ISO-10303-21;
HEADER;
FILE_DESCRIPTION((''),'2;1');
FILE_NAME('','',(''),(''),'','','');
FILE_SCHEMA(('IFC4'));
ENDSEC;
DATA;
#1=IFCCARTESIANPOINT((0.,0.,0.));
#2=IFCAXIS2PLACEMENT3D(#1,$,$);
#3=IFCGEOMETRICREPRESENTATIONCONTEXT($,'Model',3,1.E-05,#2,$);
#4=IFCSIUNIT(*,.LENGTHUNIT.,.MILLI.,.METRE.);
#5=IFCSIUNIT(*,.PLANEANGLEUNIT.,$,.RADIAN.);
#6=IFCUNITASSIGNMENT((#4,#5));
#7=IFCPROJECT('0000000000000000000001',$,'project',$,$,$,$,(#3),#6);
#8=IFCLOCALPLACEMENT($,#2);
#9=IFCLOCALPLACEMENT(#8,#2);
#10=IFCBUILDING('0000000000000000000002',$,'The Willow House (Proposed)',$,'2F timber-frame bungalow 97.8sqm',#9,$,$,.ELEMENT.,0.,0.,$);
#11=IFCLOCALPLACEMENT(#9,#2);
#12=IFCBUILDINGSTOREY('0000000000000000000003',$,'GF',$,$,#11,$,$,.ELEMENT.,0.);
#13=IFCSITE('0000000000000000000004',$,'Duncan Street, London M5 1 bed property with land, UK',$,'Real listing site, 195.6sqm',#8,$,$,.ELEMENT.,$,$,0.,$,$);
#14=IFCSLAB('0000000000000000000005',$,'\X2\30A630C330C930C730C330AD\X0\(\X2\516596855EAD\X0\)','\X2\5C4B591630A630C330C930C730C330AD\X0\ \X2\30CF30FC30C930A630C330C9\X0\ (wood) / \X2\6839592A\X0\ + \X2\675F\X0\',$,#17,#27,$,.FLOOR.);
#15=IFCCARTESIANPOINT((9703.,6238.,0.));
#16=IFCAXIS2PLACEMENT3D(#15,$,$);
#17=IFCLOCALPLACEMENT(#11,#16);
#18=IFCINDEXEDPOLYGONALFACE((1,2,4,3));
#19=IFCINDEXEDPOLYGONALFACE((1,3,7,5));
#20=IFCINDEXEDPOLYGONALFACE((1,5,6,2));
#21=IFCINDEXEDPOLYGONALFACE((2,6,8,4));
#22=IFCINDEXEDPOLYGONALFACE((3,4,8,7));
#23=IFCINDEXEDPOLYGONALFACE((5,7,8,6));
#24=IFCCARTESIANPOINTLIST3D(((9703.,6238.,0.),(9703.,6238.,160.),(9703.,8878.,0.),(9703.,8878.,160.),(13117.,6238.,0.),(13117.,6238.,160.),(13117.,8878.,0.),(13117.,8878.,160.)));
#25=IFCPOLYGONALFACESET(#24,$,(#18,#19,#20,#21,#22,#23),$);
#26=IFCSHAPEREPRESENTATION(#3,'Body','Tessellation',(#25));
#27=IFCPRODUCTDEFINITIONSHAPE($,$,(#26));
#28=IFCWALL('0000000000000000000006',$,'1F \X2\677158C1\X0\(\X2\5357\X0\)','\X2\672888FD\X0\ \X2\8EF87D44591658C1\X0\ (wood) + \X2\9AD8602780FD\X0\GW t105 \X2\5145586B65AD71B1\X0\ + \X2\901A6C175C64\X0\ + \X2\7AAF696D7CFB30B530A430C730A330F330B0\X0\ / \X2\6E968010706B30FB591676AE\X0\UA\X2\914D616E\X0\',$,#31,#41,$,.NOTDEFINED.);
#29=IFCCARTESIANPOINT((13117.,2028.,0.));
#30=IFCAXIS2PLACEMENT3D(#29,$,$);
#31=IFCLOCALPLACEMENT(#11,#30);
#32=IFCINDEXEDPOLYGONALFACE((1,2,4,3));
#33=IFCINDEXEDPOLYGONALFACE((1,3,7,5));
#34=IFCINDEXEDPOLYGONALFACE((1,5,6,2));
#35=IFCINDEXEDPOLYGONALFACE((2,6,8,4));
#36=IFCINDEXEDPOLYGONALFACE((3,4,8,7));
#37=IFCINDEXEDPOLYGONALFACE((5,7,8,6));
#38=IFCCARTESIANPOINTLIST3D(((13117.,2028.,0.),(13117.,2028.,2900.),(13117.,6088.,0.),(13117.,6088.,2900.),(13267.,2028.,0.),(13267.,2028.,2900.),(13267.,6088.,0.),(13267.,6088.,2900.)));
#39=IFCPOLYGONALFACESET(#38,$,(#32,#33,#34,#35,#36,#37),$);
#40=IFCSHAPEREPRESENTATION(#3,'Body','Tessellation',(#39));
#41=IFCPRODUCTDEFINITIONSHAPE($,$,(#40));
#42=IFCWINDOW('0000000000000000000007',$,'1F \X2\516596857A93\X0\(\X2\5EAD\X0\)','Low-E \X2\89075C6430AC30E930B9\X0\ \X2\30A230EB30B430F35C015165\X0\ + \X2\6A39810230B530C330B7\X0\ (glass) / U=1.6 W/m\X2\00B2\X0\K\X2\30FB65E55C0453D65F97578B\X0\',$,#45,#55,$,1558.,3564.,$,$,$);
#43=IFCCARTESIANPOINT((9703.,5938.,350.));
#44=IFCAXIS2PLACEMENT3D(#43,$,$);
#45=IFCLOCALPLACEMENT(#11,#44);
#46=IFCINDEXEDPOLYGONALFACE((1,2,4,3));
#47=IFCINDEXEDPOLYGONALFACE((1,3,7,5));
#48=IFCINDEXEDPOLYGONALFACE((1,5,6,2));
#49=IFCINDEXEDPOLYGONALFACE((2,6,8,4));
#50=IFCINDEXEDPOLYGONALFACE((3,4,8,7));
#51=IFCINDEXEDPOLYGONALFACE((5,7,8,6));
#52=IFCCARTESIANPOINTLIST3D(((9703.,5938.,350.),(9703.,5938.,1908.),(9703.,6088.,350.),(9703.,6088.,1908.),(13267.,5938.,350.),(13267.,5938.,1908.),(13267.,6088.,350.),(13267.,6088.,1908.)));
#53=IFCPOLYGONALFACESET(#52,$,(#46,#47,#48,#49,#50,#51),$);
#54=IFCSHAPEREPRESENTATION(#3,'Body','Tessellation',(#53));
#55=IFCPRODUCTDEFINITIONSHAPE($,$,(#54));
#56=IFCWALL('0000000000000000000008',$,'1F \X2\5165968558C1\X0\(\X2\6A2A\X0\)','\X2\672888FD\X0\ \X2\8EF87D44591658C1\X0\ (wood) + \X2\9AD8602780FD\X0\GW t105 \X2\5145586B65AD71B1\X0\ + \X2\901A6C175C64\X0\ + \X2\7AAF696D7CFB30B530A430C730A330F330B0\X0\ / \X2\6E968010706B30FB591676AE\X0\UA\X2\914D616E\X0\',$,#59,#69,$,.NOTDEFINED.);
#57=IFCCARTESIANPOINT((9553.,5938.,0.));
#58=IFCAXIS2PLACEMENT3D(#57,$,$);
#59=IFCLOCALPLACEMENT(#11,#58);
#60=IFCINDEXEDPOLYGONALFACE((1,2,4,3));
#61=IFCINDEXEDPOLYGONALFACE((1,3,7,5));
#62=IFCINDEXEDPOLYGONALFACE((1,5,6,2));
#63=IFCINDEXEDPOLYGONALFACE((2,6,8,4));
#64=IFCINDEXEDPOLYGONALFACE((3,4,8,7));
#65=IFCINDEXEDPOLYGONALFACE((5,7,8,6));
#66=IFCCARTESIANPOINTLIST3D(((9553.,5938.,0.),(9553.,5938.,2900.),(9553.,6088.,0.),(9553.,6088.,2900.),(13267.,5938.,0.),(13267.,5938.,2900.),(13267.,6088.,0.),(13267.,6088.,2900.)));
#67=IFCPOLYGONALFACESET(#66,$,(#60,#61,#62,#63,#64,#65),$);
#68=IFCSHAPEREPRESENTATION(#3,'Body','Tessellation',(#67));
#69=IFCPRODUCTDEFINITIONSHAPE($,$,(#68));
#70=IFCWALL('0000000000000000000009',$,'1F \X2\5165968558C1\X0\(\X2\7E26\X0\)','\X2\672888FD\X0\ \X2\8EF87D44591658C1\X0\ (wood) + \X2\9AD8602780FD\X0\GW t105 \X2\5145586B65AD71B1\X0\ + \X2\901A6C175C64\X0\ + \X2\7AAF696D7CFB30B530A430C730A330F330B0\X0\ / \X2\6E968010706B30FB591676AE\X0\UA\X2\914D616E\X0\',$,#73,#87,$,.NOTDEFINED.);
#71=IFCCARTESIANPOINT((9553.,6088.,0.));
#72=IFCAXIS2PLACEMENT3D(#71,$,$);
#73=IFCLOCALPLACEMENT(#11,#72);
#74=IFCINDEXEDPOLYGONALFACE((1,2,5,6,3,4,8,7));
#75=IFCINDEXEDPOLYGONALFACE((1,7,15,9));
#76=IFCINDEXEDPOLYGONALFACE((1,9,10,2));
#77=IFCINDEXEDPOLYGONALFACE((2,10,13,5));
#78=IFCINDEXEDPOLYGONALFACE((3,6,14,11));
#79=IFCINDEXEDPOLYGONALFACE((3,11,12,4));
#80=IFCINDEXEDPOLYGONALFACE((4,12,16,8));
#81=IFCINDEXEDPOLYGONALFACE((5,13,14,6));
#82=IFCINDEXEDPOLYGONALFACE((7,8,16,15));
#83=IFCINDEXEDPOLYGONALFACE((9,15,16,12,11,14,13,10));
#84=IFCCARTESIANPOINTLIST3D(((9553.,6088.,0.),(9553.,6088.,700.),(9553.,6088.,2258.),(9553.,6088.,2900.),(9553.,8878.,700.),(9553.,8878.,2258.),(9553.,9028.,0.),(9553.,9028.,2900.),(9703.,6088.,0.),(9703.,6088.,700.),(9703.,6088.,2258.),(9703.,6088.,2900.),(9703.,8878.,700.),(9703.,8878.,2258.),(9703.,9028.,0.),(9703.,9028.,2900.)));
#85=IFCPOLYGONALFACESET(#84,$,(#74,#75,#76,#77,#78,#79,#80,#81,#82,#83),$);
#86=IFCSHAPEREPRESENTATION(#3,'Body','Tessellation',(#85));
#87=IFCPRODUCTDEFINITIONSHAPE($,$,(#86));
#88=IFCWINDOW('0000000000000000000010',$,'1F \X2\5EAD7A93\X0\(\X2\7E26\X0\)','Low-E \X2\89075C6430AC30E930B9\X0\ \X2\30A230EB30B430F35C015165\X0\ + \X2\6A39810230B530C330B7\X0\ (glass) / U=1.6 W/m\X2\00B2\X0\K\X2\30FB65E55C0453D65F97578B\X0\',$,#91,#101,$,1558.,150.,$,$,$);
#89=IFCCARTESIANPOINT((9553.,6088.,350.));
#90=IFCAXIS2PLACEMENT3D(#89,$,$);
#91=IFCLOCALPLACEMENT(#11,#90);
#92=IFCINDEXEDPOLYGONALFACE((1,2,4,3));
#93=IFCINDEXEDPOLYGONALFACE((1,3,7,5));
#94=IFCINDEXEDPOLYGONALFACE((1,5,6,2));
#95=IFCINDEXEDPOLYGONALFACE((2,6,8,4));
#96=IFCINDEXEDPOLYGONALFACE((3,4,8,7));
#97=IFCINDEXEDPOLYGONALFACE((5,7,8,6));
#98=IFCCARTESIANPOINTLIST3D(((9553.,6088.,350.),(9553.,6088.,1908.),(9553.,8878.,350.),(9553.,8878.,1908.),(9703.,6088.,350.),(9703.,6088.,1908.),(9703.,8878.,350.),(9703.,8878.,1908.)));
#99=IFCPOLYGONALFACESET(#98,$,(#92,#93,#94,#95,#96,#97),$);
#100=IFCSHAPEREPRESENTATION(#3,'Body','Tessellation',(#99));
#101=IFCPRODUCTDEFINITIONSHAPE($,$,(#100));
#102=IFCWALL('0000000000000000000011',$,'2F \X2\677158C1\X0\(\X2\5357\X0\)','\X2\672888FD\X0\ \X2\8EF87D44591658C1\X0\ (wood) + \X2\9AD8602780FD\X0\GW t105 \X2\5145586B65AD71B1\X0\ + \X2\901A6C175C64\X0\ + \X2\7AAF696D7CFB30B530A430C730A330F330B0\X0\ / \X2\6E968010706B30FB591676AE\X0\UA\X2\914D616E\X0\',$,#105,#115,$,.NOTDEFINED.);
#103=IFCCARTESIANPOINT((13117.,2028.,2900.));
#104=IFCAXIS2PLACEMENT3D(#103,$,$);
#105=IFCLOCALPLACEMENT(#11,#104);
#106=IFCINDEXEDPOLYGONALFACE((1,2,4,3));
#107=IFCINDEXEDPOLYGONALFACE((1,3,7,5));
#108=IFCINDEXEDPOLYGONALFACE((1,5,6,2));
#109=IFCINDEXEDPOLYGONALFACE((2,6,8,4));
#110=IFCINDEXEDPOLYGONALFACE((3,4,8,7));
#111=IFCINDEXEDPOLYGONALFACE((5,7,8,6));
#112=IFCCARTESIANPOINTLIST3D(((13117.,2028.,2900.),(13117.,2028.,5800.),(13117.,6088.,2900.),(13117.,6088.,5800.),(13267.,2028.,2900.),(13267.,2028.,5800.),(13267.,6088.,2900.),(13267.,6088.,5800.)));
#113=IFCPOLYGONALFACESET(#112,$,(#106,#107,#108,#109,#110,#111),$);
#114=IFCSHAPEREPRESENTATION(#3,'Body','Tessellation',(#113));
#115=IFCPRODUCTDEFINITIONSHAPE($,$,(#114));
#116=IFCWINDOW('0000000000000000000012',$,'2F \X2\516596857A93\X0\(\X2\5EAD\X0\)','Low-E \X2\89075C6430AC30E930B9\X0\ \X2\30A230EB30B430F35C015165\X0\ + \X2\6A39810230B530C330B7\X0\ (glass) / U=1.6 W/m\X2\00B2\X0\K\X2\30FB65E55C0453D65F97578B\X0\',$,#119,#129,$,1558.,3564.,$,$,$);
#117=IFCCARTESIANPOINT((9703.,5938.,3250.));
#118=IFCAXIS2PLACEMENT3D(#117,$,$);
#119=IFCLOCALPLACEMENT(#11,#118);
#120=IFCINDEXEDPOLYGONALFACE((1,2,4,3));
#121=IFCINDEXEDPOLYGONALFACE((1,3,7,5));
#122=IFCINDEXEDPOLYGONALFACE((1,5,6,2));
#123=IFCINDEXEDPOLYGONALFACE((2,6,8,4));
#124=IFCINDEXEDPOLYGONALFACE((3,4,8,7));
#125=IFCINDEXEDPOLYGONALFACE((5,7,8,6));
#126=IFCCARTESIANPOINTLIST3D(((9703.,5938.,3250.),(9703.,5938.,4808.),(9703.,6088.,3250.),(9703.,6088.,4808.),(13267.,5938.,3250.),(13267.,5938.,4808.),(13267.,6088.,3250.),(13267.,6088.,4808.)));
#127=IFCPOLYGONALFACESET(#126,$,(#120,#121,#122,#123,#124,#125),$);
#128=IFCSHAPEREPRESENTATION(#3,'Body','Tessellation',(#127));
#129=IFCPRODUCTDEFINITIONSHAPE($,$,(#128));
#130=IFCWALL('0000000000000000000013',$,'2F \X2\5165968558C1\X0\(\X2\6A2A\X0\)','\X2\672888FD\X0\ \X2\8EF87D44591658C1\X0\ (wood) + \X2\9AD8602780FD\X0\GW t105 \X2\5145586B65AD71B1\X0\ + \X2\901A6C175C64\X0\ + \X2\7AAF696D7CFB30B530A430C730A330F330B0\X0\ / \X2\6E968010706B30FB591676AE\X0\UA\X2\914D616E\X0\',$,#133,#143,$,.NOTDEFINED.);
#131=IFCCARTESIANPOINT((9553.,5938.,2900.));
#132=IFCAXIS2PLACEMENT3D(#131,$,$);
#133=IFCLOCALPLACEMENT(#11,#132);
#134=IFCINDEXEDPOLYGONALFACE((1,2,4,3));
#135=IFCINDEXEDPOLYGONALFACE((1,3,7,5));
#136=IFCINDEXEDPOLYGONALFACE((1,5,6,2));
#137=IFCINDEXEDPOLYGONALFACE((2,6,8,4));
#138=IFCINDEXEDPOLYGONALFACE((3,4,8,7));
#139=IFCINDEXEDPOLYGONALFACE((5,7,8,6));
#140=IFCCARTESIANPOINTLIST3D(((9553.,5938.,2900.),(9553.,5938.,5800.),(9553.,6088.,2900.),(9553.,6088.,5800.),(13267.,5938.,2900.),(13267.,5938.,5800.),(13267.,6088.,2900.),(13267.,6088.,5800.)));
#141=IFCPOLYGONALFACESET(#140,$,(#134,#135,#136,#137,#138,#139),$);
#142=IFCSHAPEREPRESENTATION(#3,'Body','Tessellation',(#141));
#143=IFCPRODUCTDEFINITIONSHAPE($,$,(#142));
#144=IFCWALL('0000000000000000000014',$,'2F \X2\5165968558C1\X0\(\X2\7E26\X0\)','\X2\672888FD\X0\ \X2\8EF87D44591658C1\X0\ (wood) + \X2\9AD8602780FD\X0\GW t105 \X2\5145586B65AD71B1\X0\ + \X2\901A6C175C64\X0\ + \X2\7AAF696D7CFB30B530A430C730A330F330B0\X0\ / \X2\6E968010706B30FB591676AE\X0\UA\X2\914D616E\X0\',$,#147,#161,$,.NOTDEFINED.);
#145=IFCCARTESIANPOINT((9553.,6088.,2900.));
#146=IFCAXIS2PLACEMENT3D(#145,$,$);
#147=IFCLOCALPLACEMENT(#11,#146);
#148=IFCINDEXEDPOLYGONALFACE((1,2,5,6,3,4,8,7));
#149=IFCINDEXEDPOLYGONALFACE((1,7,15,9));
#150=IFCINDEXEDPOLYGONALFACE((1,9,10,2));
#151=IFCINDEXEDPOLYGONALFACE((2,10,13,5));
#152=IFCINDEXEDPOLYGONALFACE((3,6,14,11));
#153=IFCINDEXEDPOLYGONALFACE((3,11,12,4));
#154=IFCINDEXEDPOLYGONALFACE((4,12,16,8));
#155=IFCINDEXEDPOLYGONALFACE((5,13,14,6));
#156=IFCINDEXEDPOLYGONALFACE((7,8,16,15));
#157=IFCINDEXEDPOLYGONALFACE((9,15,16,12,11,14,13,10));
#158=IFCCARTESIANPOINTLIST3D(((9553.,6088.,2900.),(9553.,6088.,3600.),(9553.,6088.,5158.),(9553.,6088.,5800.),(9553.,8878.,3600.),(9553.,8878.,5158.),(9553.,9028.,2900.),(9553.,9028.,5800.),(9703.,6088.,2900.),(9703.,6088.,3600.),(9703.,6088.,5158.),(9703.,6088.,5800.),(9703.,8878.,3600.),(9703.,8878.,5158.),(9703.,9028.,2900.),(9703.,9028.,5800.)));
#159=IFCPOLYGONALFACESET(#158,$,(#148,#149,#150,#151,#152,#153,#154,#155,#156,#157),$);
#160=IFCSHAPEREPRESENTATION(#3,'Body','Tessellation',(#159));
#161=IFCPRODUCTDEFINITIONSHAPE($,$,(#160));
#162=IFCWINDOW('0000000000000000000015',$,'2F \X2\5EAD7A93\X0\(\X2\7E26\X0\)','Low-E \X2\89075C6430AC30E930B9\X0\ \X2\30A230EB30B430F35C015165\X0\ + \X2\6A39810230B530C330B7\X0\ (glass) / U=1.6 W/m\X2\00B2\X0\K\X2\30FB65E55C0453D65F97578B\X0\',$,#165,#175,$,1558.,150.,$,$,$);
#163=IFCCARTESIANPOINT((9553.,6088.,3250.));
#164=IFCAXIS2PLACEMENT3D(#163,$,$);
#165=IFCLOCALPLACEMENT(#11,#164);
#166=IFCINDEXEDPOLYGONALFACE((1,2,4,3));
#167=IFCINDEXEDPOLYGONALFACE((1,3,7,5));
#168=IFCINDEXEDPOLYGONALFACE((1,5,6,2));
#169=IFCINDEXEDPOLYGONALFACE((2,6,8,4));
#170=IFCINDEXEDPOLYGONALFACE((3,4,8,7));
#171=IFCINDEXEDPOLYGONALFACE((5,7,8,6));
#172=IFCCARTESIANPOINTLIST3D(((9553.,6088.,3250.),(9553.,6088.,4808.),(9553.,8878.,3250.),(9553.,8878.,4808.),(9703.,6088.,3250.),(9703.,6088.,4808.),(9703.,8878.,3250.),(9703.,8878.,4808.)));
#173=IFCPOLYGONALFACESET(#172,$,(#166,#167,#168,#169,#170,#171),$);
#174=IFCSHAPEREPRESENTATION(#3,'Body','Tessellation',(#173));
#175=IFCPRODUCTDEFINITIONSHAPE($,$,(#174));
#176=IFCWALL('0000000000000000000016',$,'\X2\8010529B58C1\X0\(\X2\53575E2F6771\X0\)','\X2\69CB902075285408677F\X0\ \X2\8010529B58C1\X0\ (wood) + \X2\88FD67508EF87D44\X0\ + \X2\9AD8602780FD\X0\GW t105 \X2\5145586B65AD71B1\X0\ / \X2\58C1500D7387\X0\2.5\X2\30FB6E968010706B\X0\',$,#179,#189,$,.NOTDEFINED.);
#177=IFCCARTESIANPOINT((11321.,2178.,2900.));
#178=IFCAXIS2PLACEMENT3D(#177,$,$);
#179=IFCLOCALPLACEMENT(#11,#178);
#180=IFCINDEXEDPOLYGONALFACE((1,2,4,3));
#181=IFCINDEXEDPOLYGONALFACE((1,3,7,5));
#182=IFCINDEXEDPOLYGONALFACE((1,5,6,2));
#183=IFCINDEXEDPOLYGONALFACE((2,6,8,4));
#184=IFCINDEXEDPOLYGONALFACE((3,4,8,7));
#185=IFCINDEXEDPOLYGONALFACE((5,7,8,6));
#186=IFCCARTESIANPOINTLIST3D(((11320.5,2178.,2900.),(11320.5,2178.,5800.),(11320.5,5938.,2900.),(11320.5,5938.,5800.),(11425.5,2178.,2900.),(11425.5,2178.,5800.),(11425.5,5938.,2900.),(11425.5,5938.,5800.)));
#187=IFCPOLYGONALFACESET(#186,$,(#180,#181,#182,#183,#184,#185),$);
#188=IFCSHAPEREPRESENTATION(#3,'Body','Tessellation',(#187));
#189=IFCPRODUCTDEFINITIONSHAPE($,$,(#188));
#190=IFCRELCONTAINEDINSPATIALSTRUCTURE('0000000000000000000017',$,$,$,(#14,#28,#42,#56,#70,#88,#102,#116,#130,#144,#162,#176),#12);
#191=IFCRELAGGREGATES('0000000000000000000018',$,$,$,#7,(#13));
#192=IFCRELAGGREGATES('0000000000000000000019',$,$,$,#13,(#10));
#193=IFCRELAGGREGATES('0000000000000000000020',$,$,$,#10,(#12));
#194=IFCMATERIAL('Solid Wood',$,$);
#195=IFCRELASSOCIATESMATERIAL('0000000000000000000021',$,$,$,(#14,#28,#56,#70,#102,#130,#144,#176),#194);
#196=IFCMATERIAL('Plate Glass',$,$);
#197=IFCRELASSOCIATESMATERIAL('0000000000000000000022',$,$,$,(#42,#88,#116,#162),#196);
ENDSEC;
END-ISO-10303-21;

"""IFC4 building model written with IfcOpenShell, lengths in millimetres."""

from ifc_helpers import new_model, si_unit, frame, frame_2d, origin, place, context, project, spatial, rectangle, extrude, material, element, fill, save


model = new_model("IFC4")

# Units and contexts
model_context = context("Model", 3, precision=1e-05, world=origin())
ifc_project = project(units=[si_unit("LENGTHUNIT", "METRE", prefix="MILLI"), si_unit("PLANEANGLEUNIT", "RADIAN")], contexts=[model_context])

# Site, building, storey
site_placement = place(None, origin())
site = spatial("IfcSite", under=ifc_project, at=site_placement, Name="Duncan Street, London M5 1 bed property with land, UK", ObjectType="Real listing site, 195.6sqm", CompositionType="ELEMENT", RefElevation=0.0)
building_placement = place(site_placement, origin())
building = spatial("IfcBuilding", under=site, at=building_placement, Name="The Willow House (Proposed)", ObjectType="2F timber-frame bungalow 97.8sqm", CompositionType="ELEMENT", ElevationOfRefHeight=0.0, ElevationOfTerrain=0.0)
storey_placement = place(building_placement, origin())
storey = spatial("IfcBuildingStorey", under=building, at=storey_placement, Name="GF", CompositionType="ELEMENT", Elevation=0.0)

# Slab
ifc_material_1 = material(Name="Solid Wood")
slab_placement = place(storey_placement, frame((9703.0, 6238.0, 0.0)))
element("IfcSlab", 1, at=slab_placement, inside=storey, material=ifc_material_1, Name="ウッドデッキ(入隅庭)", Description="屋外ウッドデッキ ハードウッド (wood) / 根太 + 束", PredefinedType="FLOOR", context=model_context, shape_type="SweptSolid", body=[
    extrude(rectangle(XDim=3414.0, YDim=2640.0, at=frame_2d((1707.0, 1320.0))), frame((9703.0, 6238.0, 0.0)), (0.0, 0.0, 1.0), 160.0),
])

# Wall, opening, window
wall_1_placement = place(storey_placement, frame((13117.0, 2028.0, 0.0)))
wall_1 = element("IfcWall", 2, at=wall_1_placement, inside=storey, material=ifc_material_1, Name="1F 東壁(南)", Description="木製 軸組外壁 (wood) + 高性能GW t105 充填断熱 + 通気層 + 窯業系サイディング / 準耐火・外皮UA配慮", PredefinedType="NOTDEFINED", context=model_context, shape_type="SweptSolid", body=[
    extrude(rectangle(XDim=150.0, YDim=4060.0, at=frame_2d((75.0, 2030.0))), frame((13117.0, 2028.0, 0.0)), (0.0, 0.0, 1.0), 2900.0),
])
opening_1_placement = place(storey_placement, frame((9703.0, 5938.0, 350.0)))
opening_1 = element("IfcOpeningElement", 3, at=opening_1_placement, cuts=wall_1, PredefinedType="NOTDEFINED", context=model_context, shape_type="SweptSolid", body=[
    extrude(rectangle(XDim=3564.0, YDim=150.0, at=frame_2d((1782.0, 75.0))), frame((9703.0, 5938.0, 350.0)), (0.0, 0.0, 1.0), 1558.0),
])
ifc_material_2 = material(Name="Plate Glass")
window_1_placement = place(storey_placement, frame((9703.0, 5938.0, 350.0)))
window_1 = element("IfcWindow", 4, at=window_1_placement, inside=storey, material=ifc_material_2, Name="1F 入隅窓(庭)", Description="Low-E 複層ガラス アルゴン封入 + 樹脂サッシ (glass) / U=1.6 W/m²K・日射取得型", OverallHeight=1558.0, OverallWidth=3564.0, context=model_context, shape_type="SweptSolid", body=[
    extrude(rectangle(XDim=3564.0, YDim=150.0, at=frame_2d((1782.0, 75.0))), frame((9703.0, 5938.0, 350.0)), (0.0, 0.0, 1.0), 1558.0),
])
fill(opening_1, window_1)

# Wall
wall_2_placement = place(storey_placement, frame((9553.0, 5938.0, 0.0)))
element("IfcWall", 5, at=wall_2_placement, inside=storey, material=ifc_material_1, Name="1F 入隅壁(横)", Description="木製 軸組外壁 (wood) + 高性能GW t105 充填断熱 + 通気層 + 窯業系サイディング / 準耐火・外皮UA配慮", PredefinedType="NOTDEFINED", context=model_context, shape_type="SweptSolid", body=[
    extrude(rectangle(XDim=3714.0, YDim=150.0, at=frame_2d((1857.0, 75.0))), frame((9553.0, 5938.0, 0.0)), (0.0, 0.0, 1.0), 2900.0),
])

# Wall, opening, window
wall_3_placement = place(storey_placement, frame((9553.0, 6088.0, 0.0)))
wall_3 = element("IfcWall", 6, at=wall_3_placement, inside=storey, material=ifc_material_1, Name="1F 入隅壁(縦)", Description="木製 軸組外壁 (wood) + 高性能GW t105 充填断熱 + 通気層 + 窯業系サイディング / 準耐火・外皮UA配慮", PredefinedType="NOTDEFINED", context=model_context, shape_type="SweptSolid", body=[
    extrude(rectangle(XDim=150.0, YDim=2940.0, at=frame_2d((75.0, 1470.0))), frame((9553.0, 6088.0, 0.0)), (0.0, 0.0, 1.0), 2900.0),
])
opening_2_placement = place(storey_placement, frame((9553.0, 6088.0, 350.0)))
opening_2 = element("IfcOpeningElement", 7, at=opening_2_placement, cuts=wall_3, PredefinedType="NOTDEFINED", context=model_context, shape_type="SweptSolid", body=[
    extrude(rectangle(XDim=150.0, YDim=2790.0, at=frame_2d((75.0, 1395.0))), frame((9553.0, 6088.0, 350.0)), (0.0, 0.0, 1.0), 1558.0),
])
window_2_placement = place(storey_placement, frame((9553.0, 6088.0, 350.0)))
window_2 = element("IfcWindow", 8, at=window_2_placement, inside=storey, material=ifc_material_2, Name="1F 庭窓(縦)", Description="Low-E 複層ガラス アルゴン封入 + 樹脂サッシ (glass) / U=1.6 W/m²K・日射取得型", OverallHeight=1558.0, OverallWidth=150.0, context=model_context, shape_type="SweptSolid", body=[
    extrude(rectangle(XDim=150.0, YDim=2790.0, at=frame_2d((75.0, 1395.0))), frame((9553.0, 6088.0, 350.0)), (0.0, 0.0, 1.0), 1558.0),
])
fill(opening_2, window_2)

# Wall, opening, window
wall_4_placement = place(storey_placement, frame((13117.0, 2028.0, 2900.0)))
wall_4 = element("IfcWall", 9, at=wall_4_placement, inside=storey, material=ifc_material_1, Name="2F 東壁(南)", Description="木製 軸組外壁 (wood) + 高性能GW t105 充填断熱 + 通気層 + 窯業系サイディング / 準耐火・外皮UA配慮", PredefinedType="NOTDEFINED", context=model_context, shape_type="SweptSolid", body=[
    extrude(rectangle(XDim=150.0, YDim=4060.0, at=frame_2d((75.0, 2030.0))), frame((13117.0, 2028.0, 2900.0)), (0.0, 0.0, 1.0), 2900.0),
])
opening_3_placement = place(storey_placement, frame((9703.0, 5938.0, 3250.0)))
opening_3 = element("IfcOpeningElement", 10, at=opening_3_placement, cuts=wall_4, PredefinedType="NOTDEFINED", context=model_context, shape_type="SweptSolid", body=[
    extrude(rectangle(XDim=3564.0, YDim=150.0, at=frame_2d((1782.0, 75.0))), frame((9703.0, 5938.0, 3250.0)), (0.0, 0.0, 1.0), 1558.0),
])
window_3_placement = place(storey_placement, frame((9703.0, 5938.0, 3250.0)))
window_3 = element("IfcWindow", 11, at=window_3_placement, inside=storey, material=ifc_material_2, Name="2F 入隅窓(庭)", Description="Low-E 複層ガラス アルゴン封入 + 樹脂サッシ (glass) / U=1.6 W/m²K・日射取得型", OverallHeight=1558.0, OverallWidth=3564.0, context=model_context, shape_type="SweptSolid", body=[
    extrude(rectangle(XDim=3564.0, YDim=150.0, at=frame_2d((1782.0, 75.0))), frame((9703.0, 5938.0, 3250.0)), (0.0, 0.0, 1.0), 1558.0),
])
fill(opening_3, window_3)

# Wall
wall_5_placement = place(storey_placement, frame((9553.0, 5938.0, 2900.0)))
element("IfcWall", 12, at=wall_5_placement, inside=storey, material=ifc_material_1, Name="2F 入隅壁(横)", Description="木製 軸組外壁 (wood) + 高性能GW t105 充填断熱 + 通気層 + 窯業系サイディング / 準耐火・外皮UA配慮", PredefinedType="NOTDEFINED", context=model_context, shape_type="SweptSolid", body=[
    extrude(rectangle(XDim=3714.0, YDim=150.0, at=frame_2d((1857.0, 75.0))), frame((9553.0, 5938.0, 2900.0)), (0.0, 0.0, 1.0), 2900.0),
])

# Wall, opening, window
wall_6_placement = place(storey_placement, frame((9553.0, 6088.0, 2900.0)))
wall_6 = element("IfcWall", 13, at=wall_6_placement, inside=storey, material=ifc_material_1, Name="2F 入隅壁(縦)", Description="木製 軸組外壁 (wood) + 高性能GW t105 充填断熱 + 通気層 + 窯業系サイディング / 準耐火・外皮UA配慮", PredefinedType="NOTDEFINED", context=model_context, shape_type="SweptSolid", body=[
    extrude(rectangle(XDim=150.0, YDim=2940.0, at=frame_2d((75.0, 1470.0))), frame((9553.0, 6088.0, 2900.0)), (0.0, 0.0, 1.0), 2900.0),
])
opening_4_placement = place(storey_placement, frame((9553.0, 6088.0, 3250.0)))
opening_4 = element("IfcOpeningElement", 14, at=opening_4_placement, cuts=wall_6, PredefinedType="NOTDEFINED", context=model_context, shape_type="SweptSolid", body=[
    extrude(rectangle(XDim=150.0, YDim=2790.0, at=frame_2d((75.0, 1395.0))), frame((9553.0, 6088.0, 3250.0)), (0.0, 0.0, 1.0), 1558.0),
])
window_4_placement = place(storey_placement, frame((9553.0, 6088.0, 3250.0)))
window_4 = element("IfcWindow", 15, at=window_4_placement, inside=storey, material=ifc_material_2, Name="2F 庭窓(縦)", Description="Low-E 複層ガラス アルゴン封入 + 樹脂サッシ (glass) / U=1.6 W/m²K・日射取得型", OverallHeight=1558.0, OverallWidth=150.0, context=model_context, shape_type="SweptSolid", body=[
    extrude(rectangle(XDim=150.0, YDim=2790.0, at=frame_2d((75.0, 1395.0))), frame((9553.0, 6088.0, 3250.0)), (0.0, 0.0, 1.0), 1558.0),
])
fill(opening_4, window_4)

# Wall
wall_7_placement = place(storey_placement, frame((11321.0, 2178.0, 2900.0)))
element("IfcWall", 16, at=wall_7_placement, inside=storey, material=ifc_material_1, Name="耐力壁(南帯東)", Description="構造用合板 耐力壁 (wood) + 製材軸組 + 高性能GW t105 充填断熱 / 壁倍率2.5・準耐火", PredefinedType="NOTDEFINED", context=model_context, shape_type="SweptSolid", body=[
    extrude(rectangle(XDim=105.0, YDim=3760.0, at=frame_2d((52.0, 1880.0))), frame((11321.0, 2178.0, 2900.0)), (0.0, 0.0, 1.0), 2900.0),
])

save(model, "model.ifc")
